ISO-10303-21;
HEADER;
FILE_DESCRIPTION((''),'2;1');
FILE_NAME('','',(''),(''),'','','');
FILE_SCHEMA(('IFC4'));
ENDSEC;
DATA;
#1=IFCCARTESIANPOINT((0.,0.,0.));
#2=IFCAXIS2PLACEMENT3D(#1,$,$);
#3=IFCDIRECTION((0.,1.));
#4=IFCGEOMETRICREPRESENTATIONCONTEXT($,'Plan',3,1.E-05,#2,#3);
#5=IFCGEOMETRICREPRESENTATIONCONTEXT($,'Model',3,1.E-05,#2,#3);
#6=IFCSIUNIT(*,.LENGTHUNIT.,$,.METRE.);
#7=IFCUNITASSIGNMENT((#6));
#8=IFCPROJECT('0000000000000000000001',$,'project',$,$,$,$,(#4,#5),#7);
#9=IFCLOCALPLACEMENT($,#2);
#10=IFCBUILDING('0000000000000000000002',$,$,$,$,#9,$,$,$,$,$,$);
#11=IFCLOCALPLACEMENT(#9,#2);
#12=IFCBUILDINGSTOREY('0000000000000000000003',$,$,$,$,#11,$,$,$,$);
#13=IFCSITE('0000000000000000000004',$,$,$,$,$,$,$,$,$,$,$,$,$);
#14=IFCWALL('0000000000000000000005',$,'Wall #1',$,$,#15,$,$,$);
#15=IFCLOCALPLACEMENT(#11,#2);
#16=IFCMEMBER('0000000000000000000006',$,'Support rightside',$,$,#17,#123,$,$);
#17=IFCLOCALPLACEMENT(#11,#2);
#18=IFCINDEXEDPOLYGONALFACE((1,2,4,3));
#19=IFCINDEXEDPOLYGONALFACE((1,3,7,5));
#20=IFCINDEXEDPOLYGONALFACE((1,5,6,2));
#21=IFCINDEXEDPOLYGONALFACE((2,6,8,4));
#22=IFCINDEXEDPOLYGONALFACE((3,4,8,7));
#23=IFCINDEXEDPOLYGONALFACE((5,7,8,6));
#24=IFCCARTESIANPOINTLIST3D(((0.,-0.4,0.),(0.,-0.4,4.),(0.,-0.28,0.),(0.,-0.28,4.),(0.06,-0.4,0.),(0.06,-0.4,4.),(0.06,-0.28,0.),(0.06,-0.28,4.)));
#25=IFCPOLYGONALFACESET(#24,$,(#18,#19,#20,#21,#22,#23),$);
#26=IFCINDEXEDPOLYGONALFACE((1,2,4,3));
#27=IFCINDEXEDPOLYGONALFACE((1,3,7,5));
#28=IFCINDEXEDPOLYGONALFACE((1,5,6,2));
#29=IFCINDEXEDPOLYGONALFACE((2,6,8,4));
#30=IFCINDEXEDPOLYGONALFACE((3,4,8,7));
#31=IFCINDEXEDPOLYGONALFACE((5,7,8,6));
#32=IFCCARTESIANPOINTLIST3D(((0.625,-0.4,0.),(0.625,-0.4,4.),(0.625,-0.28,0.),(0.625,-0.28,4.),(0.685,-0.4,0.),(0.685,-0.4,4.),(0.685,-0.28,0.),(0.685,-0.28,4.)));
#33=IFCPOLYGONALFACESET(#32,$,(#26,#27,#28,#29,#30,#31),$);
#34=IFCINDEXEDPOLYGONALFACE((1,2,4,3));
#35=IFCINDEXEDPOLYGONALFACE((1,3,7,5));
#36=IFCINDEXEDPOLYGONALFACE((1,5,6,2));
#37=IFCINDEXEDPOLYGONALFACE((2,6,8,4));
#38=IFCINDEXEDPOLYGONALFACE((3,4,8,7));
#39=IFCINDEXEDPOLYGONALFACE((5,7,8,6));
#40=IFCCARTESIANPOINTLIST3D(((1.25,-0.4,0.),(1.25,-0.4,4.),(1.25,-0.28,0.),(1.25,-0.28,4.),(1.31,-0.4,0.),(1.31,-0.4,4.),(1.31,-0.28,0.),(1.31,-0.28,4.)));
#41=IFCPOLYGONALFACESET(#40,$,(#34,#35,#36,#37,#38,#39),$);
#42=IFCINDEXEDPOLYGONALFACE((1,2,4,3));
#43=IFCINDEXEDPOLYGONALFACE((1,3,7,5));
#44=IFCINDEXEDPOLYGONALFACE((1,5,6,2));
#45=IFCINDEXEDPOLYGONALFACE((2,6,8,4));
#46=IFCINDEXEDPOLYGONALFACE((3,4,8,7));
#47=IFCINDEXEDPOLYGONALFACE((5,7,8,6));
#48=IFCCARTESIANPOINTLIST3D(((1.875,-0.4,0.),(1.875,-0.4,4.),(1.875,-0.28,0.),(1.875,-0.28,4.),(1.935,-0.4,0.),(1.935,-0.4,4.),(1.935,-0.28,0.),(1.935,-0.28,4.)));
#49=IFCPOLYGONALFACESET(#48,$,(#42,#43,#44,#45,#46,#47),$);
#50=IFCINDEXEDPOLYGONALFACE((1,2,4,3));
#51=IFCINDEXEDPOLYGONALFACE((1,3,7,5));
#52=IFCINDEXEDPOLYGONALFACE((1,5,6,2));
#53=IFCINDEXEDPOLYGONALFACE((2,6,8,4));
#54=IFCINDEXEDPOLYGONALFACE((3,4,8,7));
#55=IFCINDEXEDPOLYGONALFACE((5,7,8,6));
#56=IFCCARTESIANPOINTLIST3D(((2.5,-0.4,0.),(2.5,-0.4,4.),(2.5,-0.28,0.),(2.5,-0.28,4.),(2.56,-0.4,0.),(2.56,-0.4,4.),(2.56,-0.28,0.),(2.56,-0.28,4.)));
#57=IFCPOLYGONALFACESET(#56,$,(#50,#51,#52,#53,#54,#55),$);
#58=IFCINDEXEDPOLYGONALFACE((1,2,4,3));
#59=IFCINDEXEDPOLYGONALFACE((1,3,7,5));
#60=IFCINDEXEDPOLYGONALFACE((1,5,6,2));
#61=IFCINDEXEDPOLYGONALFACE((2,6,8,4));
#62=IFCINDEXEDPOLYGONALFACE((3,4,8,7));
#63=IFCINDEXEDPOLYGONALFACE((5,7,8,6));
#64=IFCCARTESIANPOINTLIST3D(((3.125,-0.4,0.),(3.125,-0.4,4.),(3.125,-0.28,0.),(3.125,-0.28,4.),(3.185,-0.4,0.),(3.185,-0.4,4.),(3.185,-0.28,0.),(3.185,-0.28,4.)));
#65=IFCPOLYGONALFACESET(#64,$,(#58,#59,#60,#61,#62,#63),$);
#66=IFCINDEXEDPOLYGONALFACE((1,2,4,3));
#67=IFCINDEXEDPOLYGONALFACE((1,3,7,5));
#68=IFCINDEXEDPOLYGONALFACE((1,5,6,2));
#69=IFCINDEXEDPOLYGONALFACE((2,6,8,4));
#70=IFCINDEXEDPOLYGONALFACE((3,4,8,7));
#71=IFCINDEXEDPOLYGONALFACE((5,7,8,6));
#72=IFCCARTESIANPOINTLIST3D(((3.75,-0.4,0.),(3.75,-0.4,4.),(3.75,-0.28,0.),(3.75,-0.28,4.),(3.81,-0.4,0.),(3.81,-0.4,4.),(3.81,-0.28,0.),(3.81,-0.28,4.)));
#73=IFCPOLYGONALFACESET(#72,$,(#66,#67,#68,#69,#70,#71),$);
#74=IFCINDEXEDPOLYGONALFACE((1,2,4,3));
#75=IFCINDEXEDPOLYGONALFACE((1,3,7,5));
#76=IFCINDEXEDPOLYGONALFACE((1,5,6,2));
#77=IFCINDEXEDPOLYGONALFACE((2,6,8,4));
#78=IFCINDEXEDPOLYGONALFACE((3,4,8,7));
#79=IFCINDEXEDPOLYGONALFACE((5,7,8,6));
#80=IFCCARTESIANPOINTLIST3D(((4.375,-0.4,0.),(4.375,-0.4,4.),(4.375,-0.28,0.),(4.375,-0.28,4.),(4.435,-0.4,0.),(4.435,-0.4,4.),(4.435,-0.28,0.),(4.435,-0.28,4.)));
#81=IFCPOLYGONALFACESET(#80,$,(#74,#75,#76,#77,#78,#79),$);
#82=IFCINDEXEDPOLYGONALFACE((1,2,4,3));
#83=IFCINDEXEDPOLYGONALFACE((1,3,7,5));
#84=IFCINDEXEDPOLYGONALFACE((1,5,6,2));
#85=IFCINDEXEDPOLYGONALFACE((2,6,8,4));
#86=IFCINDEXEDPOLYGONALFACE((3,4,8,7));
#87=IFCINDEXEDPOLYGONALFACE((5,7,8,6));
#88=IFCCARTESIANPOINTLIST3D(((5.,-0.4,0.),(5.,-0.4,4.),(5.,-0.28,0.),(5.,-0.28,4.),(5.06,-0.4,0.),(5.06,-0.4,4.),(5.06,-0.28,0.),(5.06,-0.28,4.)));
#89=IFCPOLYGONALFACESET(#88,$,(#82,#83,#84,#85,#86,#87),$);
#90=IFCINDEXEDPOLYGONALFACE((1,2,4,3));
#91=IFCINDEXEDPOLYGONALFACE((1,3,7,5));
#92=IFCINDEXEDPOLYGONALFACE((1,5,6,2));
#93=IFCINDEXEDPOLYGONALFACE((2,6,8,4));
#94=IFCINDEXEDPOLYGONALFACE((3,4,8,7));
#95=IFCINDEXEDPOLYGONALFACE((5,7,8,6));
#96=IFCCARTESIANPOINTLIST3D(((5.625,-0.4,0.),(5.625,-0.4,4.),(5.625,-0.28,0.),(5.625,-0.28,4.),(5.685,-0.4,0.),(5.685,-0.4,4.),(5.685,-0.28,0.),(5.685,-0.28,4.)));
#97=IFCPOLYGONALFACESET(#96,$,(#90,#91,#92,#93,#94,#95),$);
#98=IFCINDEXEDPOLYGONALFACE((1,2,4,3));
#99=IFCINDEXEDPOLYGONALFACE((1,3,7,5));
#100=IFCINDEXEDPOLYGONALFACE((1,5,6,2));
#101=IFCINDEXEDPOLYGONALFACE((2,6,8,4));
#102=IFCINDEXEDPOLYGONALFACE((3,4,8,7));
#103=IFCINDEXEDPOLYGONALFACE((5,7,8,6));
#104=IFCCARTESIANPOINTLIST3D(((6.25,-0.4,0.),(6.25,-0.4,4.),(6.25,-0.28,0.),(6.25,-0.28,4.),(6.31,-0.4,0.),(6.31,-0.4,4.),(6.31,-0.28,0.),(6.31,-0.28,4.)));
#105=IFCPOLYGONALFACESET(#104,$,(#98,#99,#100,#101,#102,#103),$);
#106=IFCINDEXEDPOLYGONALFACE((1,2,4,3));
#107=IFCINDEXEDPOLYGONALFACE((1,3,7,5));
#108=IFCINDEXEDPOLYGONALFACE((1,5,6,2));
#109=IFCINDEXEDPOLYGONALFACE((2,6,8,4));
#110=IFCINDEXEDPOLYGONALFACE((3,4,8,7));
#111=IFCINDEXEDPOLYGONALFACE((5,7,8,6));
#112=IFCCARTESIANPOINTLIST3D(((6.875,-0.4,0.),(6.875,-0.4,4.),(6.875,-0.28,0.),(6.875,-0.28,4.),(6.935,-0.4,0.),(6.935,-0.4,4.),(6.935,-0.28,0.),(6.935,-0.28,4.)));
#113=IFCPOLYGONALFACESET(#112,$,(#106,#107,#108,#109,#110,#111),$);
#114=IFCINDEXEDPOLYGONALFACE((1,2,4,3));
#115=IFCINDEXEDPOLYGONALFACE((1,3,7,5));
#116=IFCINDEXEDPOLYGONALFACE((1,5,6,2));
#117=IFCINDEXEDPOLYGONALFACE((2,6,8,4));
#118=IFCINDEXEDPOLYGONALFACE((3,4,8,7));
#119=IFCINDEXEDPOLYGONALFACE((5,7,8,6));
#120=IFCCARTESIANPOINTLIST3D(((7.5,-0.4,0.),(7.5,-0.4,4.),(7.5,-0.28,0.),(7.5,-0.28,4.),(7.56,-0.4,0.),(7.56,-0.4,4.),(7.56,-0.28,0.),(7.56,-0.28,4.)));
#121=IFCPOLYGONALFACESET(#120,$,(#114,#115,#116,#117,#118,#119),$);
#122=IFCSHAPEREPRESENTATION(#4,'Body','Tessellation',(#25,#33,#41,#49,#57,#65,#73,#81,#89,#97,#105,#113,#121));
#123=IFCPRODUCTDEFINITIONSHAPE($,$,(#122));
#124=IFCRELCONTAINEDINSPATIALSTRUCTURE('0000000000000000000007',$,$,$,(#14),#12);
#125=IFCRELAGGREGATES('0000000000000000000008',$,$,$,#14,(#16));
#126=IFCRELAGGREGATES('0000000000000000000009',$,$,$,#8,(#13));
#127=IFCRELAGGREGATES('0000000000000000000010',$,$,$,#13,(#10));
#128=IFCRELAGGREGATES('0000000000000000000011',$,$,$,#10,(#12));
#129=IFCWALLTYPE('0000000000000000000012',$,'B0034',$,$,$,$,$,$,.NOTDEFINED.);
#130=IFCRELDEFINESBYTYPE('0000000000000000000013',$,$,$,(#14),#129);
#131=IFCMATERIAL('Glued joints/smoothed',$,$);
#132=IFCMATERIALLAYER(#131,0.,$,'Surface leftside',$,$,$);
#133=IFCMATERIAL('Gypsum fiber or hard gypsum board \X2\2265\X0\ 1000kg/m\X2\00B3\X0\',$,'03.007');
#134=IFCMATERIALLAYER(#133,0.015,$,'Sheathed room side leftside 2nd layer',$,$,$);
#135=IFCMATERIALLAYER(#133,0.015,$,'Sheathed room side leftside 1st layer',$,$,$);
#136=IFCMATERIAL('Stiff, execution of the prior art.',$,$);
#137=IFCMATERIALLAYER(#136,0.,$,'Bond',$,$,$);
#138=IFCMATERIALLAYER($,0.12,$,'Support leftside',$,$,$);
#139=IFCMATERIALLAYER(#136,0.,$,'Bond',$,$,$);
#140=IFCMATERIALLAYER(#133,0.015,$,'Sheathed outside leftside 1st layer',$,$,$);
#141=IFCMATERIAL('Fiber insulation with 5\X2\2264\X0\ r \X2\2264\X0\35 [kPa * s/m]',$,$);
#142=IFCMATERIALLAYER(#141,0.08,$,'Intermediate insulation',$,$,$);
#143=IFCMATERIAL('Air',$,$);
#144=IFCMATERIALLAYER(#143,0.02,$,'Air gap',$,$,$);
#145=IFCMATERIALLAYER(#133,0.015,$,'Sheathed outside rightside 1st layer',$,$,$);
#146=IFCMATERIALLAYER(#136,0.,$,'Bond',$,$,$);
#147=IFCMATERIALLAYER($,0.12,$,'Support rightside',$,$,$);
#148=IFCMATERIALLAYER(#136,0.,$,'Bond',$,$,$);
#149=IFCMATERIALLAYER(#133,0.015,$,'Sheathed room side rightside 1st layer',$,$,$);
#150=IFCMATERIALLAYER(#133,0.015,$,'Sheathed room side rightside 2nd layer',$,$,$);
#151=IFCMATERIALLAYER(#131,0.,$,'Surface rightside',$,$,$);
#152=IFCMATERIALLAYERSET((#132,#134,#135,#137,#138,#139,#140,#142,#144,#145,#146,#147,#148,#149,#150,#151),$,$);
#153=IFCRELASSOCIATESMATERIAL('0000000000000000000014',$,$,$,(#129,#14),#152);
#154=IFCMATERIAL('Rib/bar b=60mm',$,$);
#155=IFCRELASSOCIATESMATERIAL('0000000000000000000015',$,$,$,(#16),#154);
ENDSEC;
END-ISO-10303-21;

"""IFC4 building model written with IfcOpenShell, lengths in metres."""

from ifc_helpers import new_model, si_unit, direction, frame, frame_2d, origin, place, context, project, spatial, rectangle, extrude, material, layer, layer_set, type_object, element, aggregate, save


model = new_model("IFC4")

# Units and contexts
plan_context = context("Plan", 3, precision=1e-05, world=origin(), true_north=direction((0.0, 1.0)))
model_context = context("Model", 3, precision=1e-05, world=origin(), true_north=direction((0.0, 1.0)))
ifc_project = project(units=[si_unit("LENGTHUNIT", "METRE")], contexts=[plan_context, model_context])

# Site, building, storey
site = spatial("IfcSite", under=ifc_project)
building_placement = place(None, origin())
building = spatial("IfcBuilding", under=site, at=building_placement)
storey_placement = place(building_placement, origin())
storey = spatial("IfcBuildingStorey", under=building, at=storey_placement)

# Wall, member
ifc_material_1 = material(Name="Glued joints/smoothed")
ifc_layer_1 = layer(ifc_material_1, 0.0, Name="Surface leftside")
ifc_material_2 = material(Name="Gypsum fiber or hard gypsum board ≥ 1000kg/m³", Category="03.007")
ifc_layer_2 = layer(ifc_material_2, 0.015, Name="Sheathed room side leftside 2nd layer")
ifc_layer_3 = layer(ifc_material_2, 0.015, Name="Sheathed room side leftside 1st layer")
ifc_material_3 = material(Name="Stiff, execution of the prior art.")
ifc_layer_4 = layer(ifc_material_3, 0.0, Name="Bond")
ifc_layer_5 = layer(None, 0.12, Name="Support leftside")
ifc_layer_6 = layer(ifc_material_3, 0.0, Name="Bond")
ifc_layer_7 = layer(ifc_material_2, 0.015, Name="Sheathed outside leftside 1st layer")
ifc_material_4 = material(Name="Fiber insulation with 5≤ r ≤35 [kPa * s/m]")
ifc_layer_8 = layer(ifc_material_4, 0.08, Name="Intermediate insulation")
ifc_material_5 = material(Name="Air")
ifc_layer_9 = layer(ifc_material_5, 0.02, Name="Air gap")
ifc_layer_10 = layer(ifc_material_2, 0.015, Name="Sheathed outside rightside 1st layer")
ifc_layer_11 = layer(ifc_material_3, 0.0, Name="Bond")
ifc_layer_12 = layer(None, 0.12, Name="Support rightside")
ifc_layer_13 = layer(ifc_material_3, 0.0, Name="Bond")
ifc_layer_14 = layer(ifc_material_2, 0.015, Name="Sheathed room side rightside 1st layer")
ifc_layer_15 = layer(ifc_material_2, 0.015, Name="Sheathed room side rightside 2nd layer")
ifc_layer_16 = layer(ifc_material_1, 0.0, Name="Surface rightside")
ifc_layer_set = layer_set([ifc_layer_1, ifc_layer_2, ifc_layer_3, ifc_layer_4, ifc_layer_5, ifc_layer_6, ifc_layer_7, ifc_layer_8, ifc_layer_9, ifc_layer_10, ifc_layer_11, ifc_layer_12, ifc_layer_13, ifc_layer_14, ifc_layer_15, ifc_layer_16])
wall_type = type_object("IfcWallType", Name="B0034", PredefinedType="NOTDEFINED", material=ifc_layer_set)
wall_placement = place(None, frame((0.0, 0.0, 0.0), z_axis=(0.0, -1.0, 0.0), x_axis=(1.0, 0.0, 0.0)))
wall = element("IfcWall", 1, at=wall_placement, inside=storey, type_object=wall_type, material=ifc_layer_set, Name="Wall #1")
ifc_material_6 = material(Name="Rib/bar b=60mm")
member_1_placement = place(wall_placement, origin())
member_1 = element("IfcMember", 2, at=member_1_placement, material=ifc_material_6, Name="Support rightside", context=plan_context, shape_type="SweptSolid", body=[
    extrude(rectangle(XDim=0.06, YDim=0.12, at=frame_2d((0.03, 0.06), x_axis=(1.0, 0.0))), frame((0.0, 4.0, 0.28), z_axis=(0.0, -1.0, 0.0), x_axis=(1.0, 0.0, 0.0)), (0.0, 0.0, 1.0), 4.0),
    extrude(rectangle(XDim=0.06, YDim=0.12, at=frame_2d((0.03, 0.06), x_axis=(1.0, 0.0))), frame((0.625, 4.0, 0.28), z_axis=(0.0, -1.0, 0.0), x_axis=(1.0, 0.0, 0.0)), (0.0, 0.0, 1.0), 4.0),
    extrude(rectangle(XDim=0.06, YDim=0.12, at=frame_2d((0.03, 0.06), x_axis=(1.0, 0.0))), frame((1.25, 4.0, 0.28), z_axis=(0.0, -1.0, 0.0), x_axis=(1.0, 0.0, 0.0)), (0.0, 0.0, 1.0), 4.0),
    extrude(rectangle(XDim=0.06, YDim=0.12, at=frame_2d((0.03, 0.06), x_axis=(1.0, 0.0))), frame((1.875, 4.0, 0.28), z_axis=(0.0, -1.0, 0.0), x_axis=(1.0, 0.0, 0.0)), (0.0, 0.0, 1.0), 4.0),
    extrude(rectangle(XDim=0.06, YDim=0.12, at=frame_2d((0.03, 0.06), x_axis=(1.0, 0.0))), frame((2.5, 4.0, 0.28), z_axis=(0.0, -1.0, 0.0), x_axis=(1.0, 0.0, 0.0)), (0.0, 0.0, 1.0), 4.0),
    extrude(rectangle(XDim=0.06, YDim=0.12, at=frame_2d((0.03, 0.06), x_axis=(1.0, 0.0))), frame((3.125, 4.0, 0.28), z_axis=(0.0, -1.0, 0.0), x_axis=(1.0, 0.0, 0.0)), (0.0, 0.0, 1.0), 4.0),
    extrude(rectangle(XDim=0.06, YDim=0.12, at=frame_2d((0.03, 0.06), x_axis=(1.0, 0.0))), frame((3.75, 4.0, 0.28), z_axis=(0.0, -1.0, 0.0), x_axis=(1.0, 0.0, 0.0)), (0.0, 0.0, 1.0), 4.0),
    extrude(rectangle(XDim=0.06, YDim=0.12, at=frame_2d((0.03, 0.06), x_axis=(1.0, 0.0))), frame((4.375, 4.0, 0.28), z_axis=(0.0, -1.0, 0.0), x_axis=(1.0, 0.0, 0.0)), (0.0, 0.0, 1.0), 4.0),
    extrude(rectangle(XDim=0.06, YDim=0.12, at=frame_2d((0.03, 0.06), x_axis=(1.0, 0.0))), frame((5.0, 4.0, 0.28), z_axis=(0.0, -1.0, 0.0), x_axis=(1.0, 0.0, 0.0)), (0.0, 0.0, 1.0), 4.0),
    extrude(rectangle(XDim=0.06, YDim=0.12, at=frame_2d((0.03, 0.06), x_axis=(1.0, 0.0))), frame((5.625, 4.0, 0.28), z_axis=(0.0, -1.0, 0.0), x_axis=(1.0, 0.0, 0.0)), (0.0, 0.0, 1.0), 4.0),
    extrude(rectangle(XDim=0.06, YDim=0.12, at=frame_2d((0.03, 0.06), x_axis=(1.0, 0.0))), frame((6.25, 4.0, 0.28), z_axis=(0.0, -1.0, 0.0), x_axis=(1.0, 0.0, 0.0)), (0.0, 0.0, 1.0), 4.0),
    extrude(rectangle(XDim=0.06, YDim=0.12, at=frame_2d((0.03, 0.06), x_axis=(1.0, 0.0))), frame((6.875, 4.0, 0.28), z_axis=(0.0, -1.0, 0.0), x_axis=(1.0, 0.0, 0.0)), (0.0, 0.0, 1.0), 4.0),
    extrude(rectangle(XDim=0.06, YDim=0.12, at=frame_2d((0.03, 0.06), x_axis=(1.0, 0.0))), frame((7.5, 4.0, 0.28), z_axis=(0.0, -1.0, 0.0), x_axis=(1.0, 0.0, 0.0)), (0.0, 0.0, 1.0), 4.0),
])
aggregate(wall, [member_1])

save(model, "model.ifc")
